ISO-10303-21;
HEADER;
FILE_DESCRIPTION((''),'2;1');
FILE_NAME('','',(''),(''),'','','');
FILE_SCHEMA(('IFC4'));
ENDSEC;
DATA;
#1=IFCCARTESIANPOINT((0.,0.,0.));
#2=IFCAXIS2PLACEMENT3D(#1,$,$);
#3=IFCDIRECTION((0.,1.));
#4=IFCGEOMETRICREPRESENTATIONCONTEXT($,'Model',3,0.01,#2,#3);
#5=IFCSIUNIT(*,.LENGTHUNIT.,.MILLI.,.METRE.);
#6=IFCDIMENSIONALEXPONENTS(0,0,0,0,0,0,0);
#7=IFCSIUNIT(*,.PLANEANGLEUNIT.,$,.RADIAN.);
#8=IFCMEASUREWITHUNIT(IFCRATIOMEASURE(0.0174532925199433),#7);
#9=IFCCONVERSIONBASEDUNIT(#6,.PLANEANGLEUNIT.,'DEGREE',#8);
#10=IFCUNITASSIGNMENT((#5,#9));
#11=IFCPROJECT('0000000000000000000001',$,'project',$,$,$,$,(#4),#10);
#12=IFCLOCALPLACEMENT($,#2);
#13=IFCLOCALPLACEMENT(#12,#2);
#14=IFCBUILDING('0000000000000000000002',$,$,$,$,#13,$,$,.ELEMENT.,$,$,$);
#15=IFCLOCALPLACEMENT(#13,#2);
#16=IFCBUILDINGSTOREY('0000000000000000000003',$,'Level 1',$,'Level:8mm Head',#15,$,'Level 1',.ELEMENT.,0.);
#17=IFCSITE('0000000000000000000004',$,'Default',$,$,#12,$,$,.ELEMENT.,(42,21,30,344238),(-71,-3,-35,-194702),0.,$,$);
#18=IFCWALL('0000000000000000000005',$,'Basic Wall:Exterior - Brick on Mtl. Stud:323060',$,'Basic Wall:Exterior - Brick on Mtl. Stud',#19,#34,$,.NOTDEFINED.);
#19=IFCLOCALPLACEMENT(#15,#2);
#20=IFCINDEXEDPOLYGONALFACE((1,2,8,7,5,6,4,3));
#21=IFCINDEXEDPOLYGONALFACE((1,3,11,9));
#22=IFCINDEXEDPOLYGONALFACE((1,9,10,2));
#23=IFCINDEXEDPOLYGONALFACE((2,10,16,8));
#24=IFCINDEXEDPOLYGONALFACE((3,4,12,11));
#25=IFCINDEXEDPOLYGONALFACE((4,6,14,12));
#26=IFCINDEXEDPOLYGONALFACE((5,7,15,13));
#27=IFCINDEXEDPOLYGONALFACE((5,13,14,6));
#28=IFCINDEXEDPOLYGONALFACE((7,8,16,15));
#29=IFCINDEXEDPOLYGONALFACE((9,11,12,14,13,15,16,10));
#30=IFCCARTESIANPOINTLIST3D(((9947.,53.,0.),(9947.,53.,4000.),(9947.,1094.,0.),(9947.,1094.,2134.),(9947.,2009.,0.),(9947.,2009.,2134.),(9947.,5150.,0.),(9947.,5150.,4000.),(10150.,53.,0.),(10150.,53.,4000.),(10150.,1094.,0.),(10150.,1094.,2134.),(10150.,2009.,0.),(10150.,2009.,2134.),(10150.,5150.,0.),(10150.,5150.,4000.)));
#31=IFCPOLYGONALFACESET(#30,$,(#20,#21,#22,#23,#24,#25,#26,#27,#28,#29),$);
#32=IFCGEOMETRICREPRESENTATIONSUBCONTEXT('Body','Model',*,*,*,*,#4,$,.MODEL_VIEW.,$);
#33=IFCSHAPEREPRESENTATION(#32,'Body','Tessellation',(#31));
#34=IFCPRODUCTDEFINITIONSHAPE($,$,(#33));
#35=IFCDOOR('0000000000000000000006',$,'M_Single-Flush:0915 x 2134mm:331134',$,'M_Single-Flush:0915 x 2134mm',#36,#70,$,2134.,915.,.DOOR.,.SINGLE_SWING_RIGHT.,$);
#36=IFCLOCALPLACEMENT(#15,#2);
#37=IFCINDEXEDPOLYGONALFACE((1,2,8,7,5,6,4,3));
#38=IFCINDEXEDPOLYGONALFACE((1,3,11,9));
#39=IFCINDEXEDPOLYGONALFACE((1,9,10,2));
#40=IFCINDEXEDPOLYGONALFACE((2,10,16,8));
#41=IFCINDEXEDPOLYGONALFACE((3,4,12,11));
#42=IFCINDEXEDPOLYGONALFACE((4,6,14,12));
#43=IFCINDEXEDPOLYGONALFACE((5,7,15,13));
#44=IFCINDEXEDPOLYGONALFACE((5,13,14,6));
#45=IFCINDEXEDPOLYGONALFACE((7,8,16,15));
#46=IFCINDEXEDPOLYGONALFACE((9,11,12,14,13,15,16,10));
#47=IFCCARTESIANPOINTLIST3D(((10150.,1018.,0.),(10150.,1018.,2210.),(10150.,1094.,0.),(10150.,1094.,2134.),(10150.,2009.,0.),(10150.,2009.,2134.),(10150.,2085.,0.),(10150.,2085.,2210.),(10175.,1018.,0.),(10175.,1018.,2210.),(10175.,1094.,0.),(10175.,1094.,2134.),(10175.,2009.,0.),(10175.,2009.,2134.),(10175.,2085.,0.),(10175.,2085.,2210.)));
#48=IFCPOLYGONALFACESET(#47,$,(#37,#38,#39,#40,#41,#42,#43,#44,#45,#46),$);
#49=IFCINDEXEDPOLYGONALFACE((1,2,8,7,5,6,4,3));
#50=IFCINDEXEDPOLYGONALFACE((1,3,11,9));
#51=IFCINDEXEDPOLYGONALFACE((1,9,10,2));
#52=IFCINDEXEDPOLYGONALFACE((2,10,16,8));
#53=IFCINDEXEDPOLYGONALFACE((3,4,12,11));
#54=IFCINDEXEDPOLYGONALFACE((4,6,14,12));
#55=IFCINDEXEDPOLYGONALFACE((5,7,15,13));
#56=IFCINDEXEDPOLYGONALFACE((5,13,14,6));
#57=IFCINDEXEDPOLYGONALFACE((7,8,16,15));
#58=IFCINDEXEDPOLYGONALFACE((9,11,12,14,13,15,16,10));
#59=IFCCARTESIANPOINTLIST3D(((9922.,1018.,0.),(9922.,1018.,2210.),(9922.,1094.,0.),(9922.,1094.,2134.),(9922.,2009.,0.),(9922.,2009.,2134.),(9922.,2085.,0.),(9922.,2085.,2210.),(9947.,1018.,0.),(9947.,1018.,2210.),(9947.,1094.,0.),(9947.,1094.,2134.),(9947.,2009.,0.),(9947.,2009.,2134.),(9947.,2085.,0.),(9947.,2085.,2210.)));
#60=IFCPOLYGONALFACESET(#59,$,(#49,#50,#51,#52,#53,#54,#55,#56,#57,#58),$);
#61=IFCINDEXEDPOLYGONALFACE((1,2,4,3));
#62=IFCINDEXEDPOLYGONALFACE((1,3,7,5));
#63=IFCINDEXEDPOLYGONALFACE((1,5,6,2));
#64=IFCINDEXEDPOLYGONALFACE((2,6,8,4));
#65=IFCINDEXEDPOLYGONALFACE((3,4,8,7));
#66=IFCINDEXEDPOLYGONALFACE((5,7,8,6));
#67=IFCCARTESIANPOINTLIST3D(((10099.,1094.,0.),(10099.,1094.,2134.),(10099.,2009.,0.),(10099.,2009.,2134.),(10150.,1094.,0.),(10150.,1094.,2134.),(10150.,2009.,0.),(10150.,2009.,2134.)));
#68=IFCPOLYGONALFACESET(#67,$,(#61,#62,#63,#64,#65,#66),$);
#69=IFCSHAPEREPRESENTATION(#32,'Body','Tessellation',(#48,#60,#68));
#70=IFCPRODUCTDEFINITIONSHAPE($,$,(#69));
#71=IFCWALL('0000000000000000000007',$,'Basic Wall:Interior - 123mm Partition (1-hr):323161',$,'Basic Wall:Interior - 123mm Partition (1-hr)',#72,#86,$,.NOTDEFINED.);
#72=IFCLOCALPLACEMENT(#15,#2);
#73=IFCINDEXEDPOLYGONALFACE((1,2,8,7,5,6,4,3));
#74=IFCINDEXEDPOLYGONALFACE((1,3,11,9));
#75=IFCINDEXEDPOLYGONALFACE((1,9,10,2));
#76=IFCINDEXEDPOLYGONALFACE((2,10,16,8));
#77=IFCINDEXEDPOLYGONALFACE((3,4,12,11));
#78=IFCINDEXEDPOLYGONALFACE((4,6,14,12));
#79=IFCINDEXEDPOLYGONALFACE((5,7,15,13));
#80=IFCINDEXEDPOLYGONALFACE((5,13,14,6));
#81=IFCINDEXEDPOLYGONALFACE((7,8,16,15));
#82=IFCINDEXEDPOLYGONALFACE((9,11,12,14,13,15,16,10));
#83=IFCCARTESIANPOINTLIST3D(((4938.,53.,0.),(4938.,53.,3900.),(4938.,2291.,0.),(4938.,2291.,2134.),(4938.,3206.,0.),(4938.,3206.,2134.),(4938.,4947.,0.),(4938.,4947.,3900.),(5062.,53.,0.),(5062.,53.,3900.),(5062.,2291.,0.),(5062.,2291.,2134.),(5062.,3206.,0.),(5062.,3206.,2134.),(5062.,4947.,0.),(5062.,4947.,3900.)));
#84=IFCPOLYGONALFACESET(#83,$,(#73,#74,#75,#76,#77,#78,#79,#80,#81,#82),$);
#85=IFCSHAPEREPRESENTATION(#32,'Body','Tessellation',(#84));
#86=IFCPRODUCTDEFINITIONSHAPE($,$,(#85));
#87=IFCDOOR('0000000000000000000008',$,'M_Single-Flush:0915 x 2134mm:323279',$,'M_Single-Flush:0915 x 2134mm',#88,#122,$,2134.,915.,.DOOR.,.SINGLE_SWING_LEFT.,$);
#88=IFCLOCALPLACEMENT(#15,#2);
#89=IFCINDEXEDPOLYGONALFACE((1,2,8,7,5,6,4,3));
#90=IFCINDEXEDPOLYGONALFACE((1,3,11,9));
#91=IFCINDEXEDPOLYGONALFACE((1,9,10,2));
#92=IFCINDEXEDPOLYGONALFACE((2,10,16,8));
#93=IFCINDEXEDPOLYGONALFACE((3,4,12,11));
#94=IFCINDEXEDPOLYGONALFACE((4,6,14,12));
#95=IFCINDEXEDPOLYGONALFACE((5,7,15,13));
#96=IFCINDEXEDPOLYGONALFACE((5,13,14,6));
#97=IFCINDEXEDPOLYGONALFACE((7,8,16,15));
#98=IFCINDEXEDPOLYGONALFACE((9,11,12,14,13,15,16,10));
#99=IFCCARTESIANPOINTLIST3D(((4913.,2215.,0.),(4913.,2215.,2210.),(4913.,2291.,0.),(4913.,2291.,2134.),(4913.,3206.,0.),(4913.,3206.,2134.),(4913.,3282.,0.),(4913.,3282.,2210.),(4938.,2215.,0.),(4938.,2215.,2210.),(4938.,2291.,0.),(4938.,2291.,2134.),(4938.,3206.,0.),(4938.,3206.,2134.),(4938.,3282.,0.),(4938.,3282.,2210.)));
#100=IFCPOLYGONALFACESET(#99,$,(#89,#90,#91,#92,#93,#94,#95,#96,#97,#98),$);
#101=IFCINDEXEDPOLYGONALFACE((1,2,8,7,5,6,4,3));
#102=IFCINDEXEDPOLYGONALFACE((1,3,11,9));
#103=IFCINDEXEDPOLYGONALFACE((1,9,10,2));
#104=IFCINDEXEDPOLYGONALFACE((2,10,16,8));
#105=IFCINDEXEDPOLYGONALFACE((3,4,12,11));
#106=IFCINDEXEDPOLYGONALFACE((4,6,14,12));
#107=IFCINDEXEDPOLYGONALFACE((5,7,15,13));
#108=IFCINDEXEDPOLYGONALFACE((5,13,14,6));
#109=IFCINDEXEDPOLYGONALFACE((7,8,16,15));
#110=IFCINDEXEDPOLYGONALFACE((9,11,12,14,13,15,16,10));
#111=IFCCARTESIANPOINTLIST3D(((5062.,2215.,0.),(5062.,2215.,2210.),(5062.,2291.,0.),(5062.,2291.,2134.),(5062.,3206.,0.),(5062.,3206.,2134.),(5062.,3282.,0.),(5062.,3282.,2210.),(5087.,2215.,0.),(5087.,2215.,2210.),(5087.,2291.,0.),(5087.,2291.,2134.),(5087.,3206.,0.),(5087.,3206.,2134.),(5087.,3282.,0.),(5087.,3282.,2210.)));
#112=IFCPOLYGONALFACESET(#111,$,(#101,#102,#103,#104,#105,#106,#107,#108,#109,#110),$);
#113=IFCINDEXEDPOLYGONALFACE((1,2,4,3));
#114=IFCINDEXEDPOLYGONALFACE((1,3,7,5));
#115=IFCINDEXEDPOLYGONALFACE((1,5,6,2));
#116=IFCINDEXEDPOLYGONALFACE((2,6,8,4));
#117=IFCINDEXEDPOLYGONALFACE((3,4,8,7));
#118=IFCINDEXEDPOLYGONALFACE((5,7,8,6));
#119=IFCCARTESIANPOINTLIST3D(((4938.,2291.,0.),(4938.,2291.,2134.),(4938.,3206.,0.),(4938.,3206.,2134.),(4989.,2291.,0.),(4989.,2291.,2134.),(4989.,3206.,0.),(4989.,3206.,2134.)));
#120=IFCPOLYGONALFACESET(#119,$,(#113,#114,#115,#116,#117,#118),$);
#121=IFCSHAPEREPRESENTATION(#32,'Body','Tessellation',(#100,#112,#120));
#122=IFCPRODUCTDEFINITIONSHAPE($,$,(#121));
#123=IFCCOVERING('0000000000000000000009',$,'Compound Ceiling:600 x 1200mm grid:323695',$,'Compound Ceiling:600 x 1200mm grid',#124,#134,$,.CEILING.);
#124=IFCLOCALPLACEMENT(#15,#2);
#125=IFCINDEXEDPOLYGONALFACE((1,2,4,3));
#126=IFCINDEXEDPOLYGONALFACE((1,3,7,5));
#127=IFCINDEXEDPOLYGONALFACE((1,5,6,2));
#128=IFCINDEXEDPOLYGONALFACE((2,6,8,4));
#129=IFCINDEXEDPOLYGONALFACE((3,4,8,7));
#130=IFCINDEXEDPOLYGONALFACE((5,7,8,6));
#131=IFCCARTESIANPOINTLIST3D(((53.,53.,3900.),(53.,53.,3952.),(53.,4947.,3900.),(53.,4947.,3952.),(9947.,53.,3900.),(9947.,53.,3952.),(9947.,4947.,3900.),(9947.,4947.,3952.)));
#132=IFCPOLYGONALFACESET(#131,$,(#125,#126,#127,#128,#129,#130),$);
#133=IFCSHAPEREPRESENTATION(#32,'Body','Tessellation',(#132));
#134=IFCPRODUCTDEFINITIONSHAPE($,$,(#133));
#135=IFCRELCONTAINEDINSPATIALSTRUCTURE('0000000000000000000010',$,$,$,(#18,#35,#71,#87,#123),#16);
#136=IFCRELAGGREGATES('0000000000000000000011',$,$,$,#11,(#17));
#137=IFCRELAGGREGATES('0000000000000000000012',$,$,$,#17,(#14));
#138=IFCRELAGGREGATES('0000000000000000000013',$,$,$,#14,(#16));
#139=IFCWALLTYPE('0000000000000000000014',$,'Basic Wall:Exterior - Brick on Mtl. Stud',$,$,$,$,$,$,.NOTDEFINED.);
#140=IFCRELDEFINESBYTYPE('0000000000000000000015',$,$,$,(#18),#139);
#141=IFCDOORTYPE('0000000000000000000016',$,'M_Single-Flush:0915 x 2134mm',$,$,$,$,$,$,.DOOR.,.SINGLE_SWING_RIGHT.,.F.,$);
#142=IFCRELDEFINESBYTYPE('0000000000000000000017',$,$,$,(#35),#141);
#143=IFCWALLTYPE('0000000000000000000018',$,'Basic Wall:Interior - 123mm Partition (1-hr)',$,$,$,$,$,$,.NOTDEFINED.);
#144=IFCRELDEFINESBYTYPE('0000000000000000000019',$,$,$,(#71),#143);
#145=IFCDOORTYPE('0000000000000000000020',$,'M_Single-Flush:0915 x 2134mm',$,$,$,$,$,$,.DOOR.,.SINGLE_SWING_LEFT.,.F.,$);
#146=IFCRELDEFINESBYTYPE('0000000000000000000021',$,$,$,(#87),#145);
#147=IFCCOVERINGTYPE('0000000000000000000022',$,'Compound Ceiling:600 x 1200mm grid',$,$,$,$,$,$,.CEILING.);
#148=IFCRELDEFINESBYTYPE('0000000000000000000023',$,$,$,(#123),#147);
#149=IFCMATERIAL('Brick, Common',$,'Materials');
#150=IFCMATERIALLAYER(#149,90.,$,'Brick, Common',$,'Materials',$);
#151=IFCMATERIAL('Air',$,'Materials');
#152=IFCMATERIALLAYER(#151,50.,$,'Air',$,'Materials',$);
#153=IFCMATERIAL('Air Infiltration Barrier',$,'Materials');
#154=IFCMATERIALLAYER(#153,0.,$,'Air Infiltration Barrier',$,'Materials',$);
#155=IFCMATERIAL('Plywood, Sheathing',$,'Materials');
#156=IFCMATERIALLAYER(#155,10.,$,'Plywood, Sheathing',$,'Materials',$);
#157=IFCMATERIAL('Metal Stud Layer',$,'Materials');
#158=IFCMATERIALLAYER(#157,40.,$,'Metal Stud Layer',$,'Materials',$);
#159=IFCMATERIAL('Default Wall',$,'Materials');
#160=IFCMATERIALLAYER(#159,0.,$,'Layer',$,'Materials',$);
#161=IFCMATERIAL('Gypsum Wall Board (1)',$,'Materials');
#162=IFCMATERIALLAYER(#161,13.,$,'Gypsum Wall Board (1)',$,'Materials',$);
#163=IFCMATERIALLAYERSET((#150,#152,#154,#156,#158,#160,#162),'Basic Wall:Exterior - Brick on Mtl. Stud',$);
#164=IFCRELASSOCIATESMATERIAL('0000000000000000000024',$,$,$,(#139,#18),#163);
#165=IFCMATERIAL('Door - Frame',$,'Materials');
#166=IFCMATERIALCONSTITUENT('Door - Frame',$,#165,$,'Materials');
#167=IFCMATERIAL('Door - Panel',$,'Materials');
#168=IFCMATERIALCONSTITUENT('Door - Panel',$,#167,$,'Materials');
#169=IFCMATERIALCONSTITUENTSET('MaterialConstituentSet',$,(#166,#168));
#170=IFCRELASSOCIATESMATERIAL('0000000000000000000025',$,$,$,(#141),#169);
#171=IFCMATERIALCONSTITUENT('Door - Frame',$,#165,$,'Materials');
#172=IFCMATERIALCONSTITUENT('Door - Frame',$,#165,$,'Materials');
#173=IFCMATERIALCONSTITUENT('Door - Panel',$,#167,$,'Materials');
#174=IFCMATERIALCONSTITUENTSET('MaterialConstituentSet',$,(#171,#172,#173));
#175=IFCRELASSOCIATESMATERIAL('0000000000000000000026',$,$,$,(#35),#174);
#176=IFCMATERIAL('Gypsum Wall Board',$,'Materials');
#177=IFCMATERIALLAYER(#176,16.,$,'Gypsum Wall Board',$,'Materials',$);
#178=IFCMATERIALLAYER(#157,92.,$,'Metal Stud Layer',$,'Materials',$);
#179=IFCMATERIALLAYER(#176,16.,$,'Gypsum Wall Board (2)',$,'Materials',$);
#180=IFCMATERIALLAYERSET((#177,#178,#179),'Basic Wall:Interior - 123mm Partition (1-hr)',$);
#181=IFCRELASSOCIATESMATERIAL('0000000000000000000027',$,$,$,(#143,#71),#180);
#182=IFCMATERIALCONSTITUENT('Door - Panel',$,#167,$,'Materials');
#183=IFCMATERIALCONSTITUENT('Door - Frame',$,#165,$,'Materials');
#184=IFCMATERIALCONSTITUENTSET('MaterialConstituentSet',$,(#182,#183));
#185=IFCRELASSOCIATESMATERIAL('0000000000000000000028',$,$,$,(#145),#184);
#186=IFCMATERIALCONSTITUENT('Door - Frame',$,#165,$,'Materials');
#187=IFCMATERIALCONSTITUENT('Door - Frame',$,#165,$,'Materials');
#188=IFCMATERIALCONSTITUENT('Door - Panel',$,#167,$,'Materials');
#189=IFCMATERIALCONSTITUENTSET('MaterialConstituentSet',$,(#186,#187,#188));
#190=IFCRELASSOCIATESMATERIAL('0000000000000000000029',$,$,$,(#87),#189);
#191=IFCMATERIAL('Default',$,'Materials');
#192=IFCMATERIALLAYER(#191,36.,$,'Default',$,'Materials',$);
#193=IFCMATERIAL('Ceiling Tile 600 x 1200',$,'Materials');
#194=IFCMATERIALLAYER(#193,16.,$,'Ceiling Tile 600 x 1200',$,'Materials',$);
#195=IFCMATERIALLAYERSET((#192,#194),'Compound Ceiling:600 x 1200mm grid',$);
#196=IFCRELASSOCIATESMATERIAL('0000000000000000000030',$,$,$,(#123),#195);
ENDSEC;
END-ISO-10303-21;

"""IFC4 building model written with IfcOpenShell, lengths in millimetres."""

from ifc_helpers import new_model, entity, si_unit, converted_unit, direction, frame, frame_2d, origin, origin_2d_with_axis, place, context, subcontext, project, spatial, polyline, rectangle, outline, extrude, source, transform, mapped, material, layer, layer_set, layer_usage, constituent, constituent_set, type_object, type_shapes, element, fill, save


model = new_model("IFC4")

# Units and contexts
model_context = context("Model", 3, precision=0.01, world=origin(), true_north=direction((0.0, 1.0)))
body_context = subcontext(model_context, "Body", "Model", "MODEL_VIEW")
ifc_project = project(units=[si_unit("LENGTHUNIT", "METRE", prefix="MILLI"), converted_unit("PLANEANGLEUNIT", "DEGREE", entity("IfcRatioMeasure", 0.0174532925199433), si_unit("PLANEANGLEUNIT", "RADIAN"), dimensions=[0, 0, 0, 0, 0, 0, 0])], contexts=[model_context])

# Site, building, storey
site_placement = place(None, origin())
site = spatial("IfcSite", under=ifc_project, at=site_placement, Name="Default", CompositionType="ELEMENT", RefLatitude=(42, 21, 30, 344238), RefLongitude=(-71, -3, -35, -194702), RefElevation=0.0)
building_placement = place(site_placement, origin())
building = spatial("IfcBuilding", under=site, at=building_placement, CompositionType="ELEMENT")
storey_placement = place(building_placement, origin())
storey = spatial("IfcBuildingStorey", under=building, at=storey_placement, Name="Level 1", ObjectType="Level:8mm Head", LongName="Level 1", CompositionType="ELEMENT", Elevation=0.0)

# Shared definitions
ifc_material_1 = material(Name="Brick, Common", Category="Materials")
ifc_layer_1 = layer(ifc_material_1, 90.0, Name="Brick, Common", Category="Materials")
ifc_material_2 = material(Name="Air", Category="Materials")
ifc_layer_2 = layer(ifc_material_2, 50.0, Name="Air", Category="Materials")
ifc_material_3 = material(Name="Air Infiltration Barrier", Category="Materials")
ifc_layer_3 = layer(ifc_material_3, 0.0, Name="Air Infiltration Barrier", Category="Materials")
ifc_material_4 = material(Name="Plywood, Sheathing", Category="Materials")
ifc_layer_4 = layer(ifc_material_4, 10.0, Name="Plywood, Sheathing", Category="Materials")
ifc_material_5 = material(Name="Metal Stud Layer", Category="Materials")
ifc_layer_5 = layer(ifc_material_5, 40.0, Name="Metal Stud Layer", Category="Materials")
ifc_material_6 = material(Name="Default Wall", Category="Materials")
ifc_layer_6 = layer(ifc_material_6, 0.0, Name="Layer", Category="Materials")
ifc_material_7 = material(Name="Gypsum Wall Board (1)", Category="Materials")
ifc_layer_7 = layer(ifc_material_7, 13.0, Name="Gypsum Wall Board (1)", Category="Materials")
ifc_layer_set_1 = layer_set([ifc_layer_1, ifc_layer_2, ifc_layer_3, ifc_layer_4, ifc_layer_5, ifc_layer_6, ifc_layer_7], Name="Basic Wall:Exterior - Brick on Mtl. Stud")
wall_type_1 = type_object("IfcWallType", Name="Basic Wall:Exterior - Brick on Mtl. Stud", PredefinedType="NOTDEFINED", material=ifc_layer_set_1)

# Walls, openings, doors
ifc_layer_usage_1 = layer_usage(ifc_layer_set_1, "AXIS2", "NEGATIVE", 101.5)
wall_1_placement = place(storey_placement, frame((10048.5, 5150.0, 0.0), z_axis=(0.0, 0.0, 1.0), x_axis=(0.0, -1.0, 0.0)))
wall_1 = element("IfcWall", 1, at=wall_1_placement, inside=storey, type_object=wall_type_1, material=ifc_layer_usage_1, Name="Basic Wall:Exterior - Brick on Mtl. Stud:323060", ObjectType="Basic Wall:Exterior - Brick on Mtl. Stud", PredefinedType="NOTDEFINED", context=body_context, shape_type="SweptSolid", body=[
    extrude(rectangle(XDim=5097.0, YDim=203.0, at=frame_2d((2548.5, 0.0), x_axis=(-1.0, 0.0))), origin(), (0.0, 0.0, 1.0), 4000.0),
])
opening_1_placement = place(wall_1_placement, frame((3141.0, -101.5, 0.0)))
opening_1 = element("IfcOpeningElement", 2, at=opening_1_placement, cuts=wall_1, ObjectType="Opening", PredefinedType="OPENING", context=body_context, shape_type="SweptSolid", body=[
    extrude(rectangle(XDim=915.0, YDim=2134.0, at=frame_2d((1067.0, 457.5), x_axis=(0.0, 1.0))), frame((0.0, 0.0, 0.0), z_axis=(0.0, 1.0, 0.0), x_axis=(0.0, 0.0, 1.0)), (0.0, 0.0, 1.0), 203.0),
])
ifc_material_8 = material(Name="Door - Frame", Category="Materials")
ifc_constituent_1 = constituent(ifc_material_8, Name="Door - Frame", Category="Materials")
ifc_constituent_2 = constituent(ifc_material_8, Name="Door - Frame", Category="Materials")
ifc_material_9 = material(Name="Door - Panel", Category="Materials")
ifc_constituent_3 = constituent(ifc_material_9, Name="Door - Panel", Category="Materials")
ifc_constituent_set_1 = constituent_set(constituents=[ifc_constituent_1, ifc_constituent_2, ifc_constituent_3], Name="MaterialConstituentSet")
ifc_constituent_4 = constituent(ifc_material_8, Name="Door - Frame", Category="Materials")
ifc_constituent_5 = constituent(ifc_material_9, Name="Door - Panel", Category="Materials")
ifc_constituent_set_2 = constituent_set(constituents=[ifc_constituent_4, ifc_constituent_5], Name="MaterialConstituentSet")
door_type_1 = type_object("IfcDoorType", Name="M_Single-Flush:0915 x 2134mm", OperationType="SINGLE_SWING_RIGHT", ParameterTakesPrecedence=False, PredefinedType="DOOR", material=ifc_constituent_set_2)
shared_shape_1 = source(origin(), body_context, "Body", "SweptSolid", [
    extrude(outline(polyline([(-533.5, -1124.0), (533.5, -1124.0), (533.5, 1086.0), (457.5, 1086.0), (457.5, -1048.0), (-457.5, -1048.0), (-457.5, 1086.0), (-533.5, 1086.0), (-533.5, -1124.0)])), frame((457.5, 203.0, 1086.0), z_axis=(0.0, 1.0, 0.0), x_axis=(1.0, 0.0, 0.0)), (0.0, 0.0, 1.0), 25.0),
    extrude(outline(polyline([(-1124.0, -533.5), (1086.0, -533.5), (1086.0, -457.5), (-1048.0, -457.5), (-1048.0, 457.5), (1086.0, 457.5), (1086.0, 533.5), (-1124.0, 533.5), (-1124.0, -533.5)])), frame((457.5, -25.0, 1086.0), z_axis=(0.0, 1.0, 0.0), x_axis=(0.0, 0.0, -1.0)), (0.0, 0.0, 1.0), 25.0),
    extrude(rectangle(XDim=51.0, YDim=915.0, at=frame_2d((0.0, 0.0), x_axis=(1.0, 0.0))), frame((457.5, 177.5, 0.0), z_axis=(0.0, 0.0, 1.0), x_axis=(0.0, 1.0, 0.0)), (0.0, 0.0, 1.0), 2134.0),
])
type_shapes(door_type_1, [shared_shape_1])
door_1_placement = place(opening_1_placement, origin())
door_1 = element("IfcDoor", 3, at=door_1_placement, inside=storey, type_object=door_type_1, material=ifc_constituent_set_1, Name="M_Single-Flush:0915 x 2134mm:331134", ObjectType="M_Single-Flush:0915 x 2134mm", OperationType="SINGLE_SWING_RIGHT", OverallHeight=2134.0, OverallWidth=915.0, PredefinedType="DOOR", context=body_context, shape_type="MappedRepresentation", body=[
    mapped(shared_shape_1, transform((0.0, 0.0, 0.0), scale=1.0)),
])
fill(opening_1, door_1)
ifc_material_10 = material(Name="Gypsum Wall Board", Category="Materials")
ifc_layer_8 = layer(ifc_material_10, 16.0, Name="Gypsum Wall Board", Category="Materials")
ifc_layer_9 = layer(ifc_material_5, 92.0, Name="Metal Stud Layer", Category="Materials")
ifc_layer_10 = layer(ifc_material_10, 16.0, Name="Gypsum Wall Board (2)", Category="Materials")
ifc_layer_set_2 = layer_set([ifc_layer_8, ifc_layer_9, ifc_layer_10], Name="Basic Wall:Interior - 123mm Partition (1-hr)")
ifc_layer_usage_2 = layer_usage(ifc_layer_set_2, "AXIS2", "NEGATIVE", 62.0)
wall_type_2 = type_object("IfcWallType", Name="Basic Wall:Interior - 123mm Partition (1-hr)", PredefinedType="NOTDEFINED", material=ifc_layer_set_2)
wall_2_placement = place(storey_placement, frame((5000.0, 4947.0, 0.0), z_axis=(0.0, 0.0, 1.0), x_axis=(0.0, -1.0, 0.0)))
wall_2 = element("IfcWall", 4, at=wall_2_placement, inside=storey, type_object=wall_type_2, material=ifc_layer_usage_2, Name="Basic Wall:Interior - 123mm Partition (1-hr):323161", ObjectType="Basic Wall:Interior - 123mm Partition (1-hr)", PredefinedType="NOTDEFINED", context=body_context, shape_type="SweptSolid", body=[
    extrude(rectangle(XDim=4894.0, YDim=124.0, at=frame_2d((2447.0, 0.0), x_axis=(-1.0, 0.0))), origin(), (0.0, 0.0, 1.0), 3900.0),
])
opening_2_placement = place(wall_2_placement, frame((2656.0, 62.0, 0.0)))
opening_2 = element("IfcOpeningElement", 5, at=opening_2_placement, cuts=wall_2, ObjectType="Opening", PredefinedType="OPENING", context=body_context, shape_type="SweptSolid", body=[
    extrude(rectangle(XDim=915.0, YDim=2134.0, at=frame_2d((1067.0, 457.5), x_axis=(0.0, -1.0))), frame((0.0, 0.0, 0.0), z_axis=(0.0, -1.0, 0.0), x_axis=(0.0, 0.0, 1.0)), (0.0, 0.0, 1.0), 124.0),
])
ifc_constituent_6 = constituent(ifc_material_8, Name="Door - Frame", Category="Materials")
ifc_constituent_7 = constituent(ifc_material_8, Name="Door - Frame", Category="Materials")
ifc_constituent_8 = constituent(ifc_material_9, Name="Door - Panel", Category="Materials")
ifc_constituent_set_3 = constituent_set(constituents=[ifc_constituent_6, ifc_constituent_7, ifc_constituent_8], Name="MaterialConstituentSet")
ifc_constituent_9 = constituent(ifc_material_9, Name="Door - Panel", Category="Materials")
ifc_constituent_10 = constituent(ifc_material_8, Name="Door - Frame", Category="Materials")
ifc_constituent_set_4 = constituent_set(constituents=[ifc_constituent_9, ifc_constituent_10], Name="MaterialConstituentSet")
door_type_2 = type_object("IfcDoorType", Name="M_Single-Flush:0915 x 2134mm", OperationType="SINGLE_SWING_LEFT", ParameterTakesPrecedence=False, PredefinedType="DOOR", material=ifc_constituent_set_4)
shared_shape_2 = source(origin(), body_context, "Body", "SweptSolid", [
    extrude(outline(polyline([(-533.5, -1124.0), (533.5, -1124.0), (533.5, 1086.0), (457.5, 1086.0), (457.5, -1048.0), (-457.5, -1048.0), (-457.5, 1086.0), (-533.5, 1086.0), (-533.5, -1124.0)])), frame((457.5, 149.0, 1086.0), z_axis=(0.0, -1.0, 0.0), x_axis=(-1.0, 0.0, 0.0)), (0.0, 0.0, 1.0), 25.0),
    extrude(outline(polyline([(-1124.0, -533.5), (1086.0, -533.5), (1086.0, -457.5), (-1048.0, -457.5), (-1048.0, 457.5), (1086.0, 457.5), (1086.0, 533.5), (-1124.0, 533.5), (-1124.0, -533.5)])), frame((457.5, 0.0, 1086.0), z_axis=(0.0, -1.0, 0.0), x_axis=(0.0, 0.0, -1.0)), (0.0, 0.0, 1.0), 25.0),
    extrude(rectangle(XDim=915.0, YDim=51.0, at=origin_2d_with_axis()), frame((457.5, 98.5, 0.0)), (0.0, 0.0, 1.0), 2134.0),
])
type_shapes(door_type_2, [shared_shape_2])
door_2_placement = place(opening_2_placement, frame((0.0, 0.0, 0.0), z_axis=(0.0, 0.0, 1.0), x_axis=(-1.0, 0.0, 0.0)))
door_2 = element("IfcDoor", 6, at=door_2_placement, inside=storey, type_object=door_type_2, material=ifc_constituent_set_3, Name="M_Single-Flush:0915 x 2134mm:323279", ObjectType="M_Single-Flush:0915 x 2134mm", OperationType="SINGLE_SWING_LEFT", OverallHeight=2134.0, OverallWidth=915.0, PredefinedType="DOOR", context=body_context, shape_type="MappedRepresentation", body=[
    mapped(shared_shape_2, transform((0.0, 0.0, 0.0), scale=1.0)),
])
fill(opening_2, door_2)

# Covering
ifc_material_11 = material(Name="Default", Category="Materials")
ifc_layer_11 = layer(ifc_material_11, 36.0, Name="Default", Category="Materials")
ifc_material_12 = material(Name="Ceiling Tile 600 x 1200", Category="Materials")
ifc_layer_12 = layer(ifc_material_12, 16.0, Name="Ceiling Tile 600 x 1200", Category="Materials")
ifc_layer_set_3 = layer_set([ifc_layer_11, ifc_layer_12], Name="Compound Ceiling:600 x 1200mm grid")
ifc_layer_usage_3 = layer_usage(ifc_layer_set_3, "AXIS3", "POSITIVE", 0.0)
covering_type = type_object("IfcCoveringType", Name="Compound Ceiling:600 x 1200mm grid", PredefinedType="CEILING")
covering_placement = place(storey_placement, frame((53.0, 53.0, 3900.0)))
element("IfcCovering", 7, at=covering_placement, inside=storey, type_object=covering_type, material=ifc_layer_usage_3, Name="Compound Ceiling:600 x 1200mm grid:323695", ObjectType="Compound Ceiling:600 x 1200mm grid", PredefinedType="CEILING", context=body_context, shape_type="SweptSolid", body=[
    extrude(rectangle(XDim=9894.0, YDim=4894.0, at=origin_2d_with_axis()), frame((4947.0, 2447.0, 0.0), z_axis=(0.0, 0.0, 1.0), x_axis=(-1.0, 0.0, 0.0)), (0.0, 0.0, 1.0), 52.0),
])

save(model, "model.ifc")
